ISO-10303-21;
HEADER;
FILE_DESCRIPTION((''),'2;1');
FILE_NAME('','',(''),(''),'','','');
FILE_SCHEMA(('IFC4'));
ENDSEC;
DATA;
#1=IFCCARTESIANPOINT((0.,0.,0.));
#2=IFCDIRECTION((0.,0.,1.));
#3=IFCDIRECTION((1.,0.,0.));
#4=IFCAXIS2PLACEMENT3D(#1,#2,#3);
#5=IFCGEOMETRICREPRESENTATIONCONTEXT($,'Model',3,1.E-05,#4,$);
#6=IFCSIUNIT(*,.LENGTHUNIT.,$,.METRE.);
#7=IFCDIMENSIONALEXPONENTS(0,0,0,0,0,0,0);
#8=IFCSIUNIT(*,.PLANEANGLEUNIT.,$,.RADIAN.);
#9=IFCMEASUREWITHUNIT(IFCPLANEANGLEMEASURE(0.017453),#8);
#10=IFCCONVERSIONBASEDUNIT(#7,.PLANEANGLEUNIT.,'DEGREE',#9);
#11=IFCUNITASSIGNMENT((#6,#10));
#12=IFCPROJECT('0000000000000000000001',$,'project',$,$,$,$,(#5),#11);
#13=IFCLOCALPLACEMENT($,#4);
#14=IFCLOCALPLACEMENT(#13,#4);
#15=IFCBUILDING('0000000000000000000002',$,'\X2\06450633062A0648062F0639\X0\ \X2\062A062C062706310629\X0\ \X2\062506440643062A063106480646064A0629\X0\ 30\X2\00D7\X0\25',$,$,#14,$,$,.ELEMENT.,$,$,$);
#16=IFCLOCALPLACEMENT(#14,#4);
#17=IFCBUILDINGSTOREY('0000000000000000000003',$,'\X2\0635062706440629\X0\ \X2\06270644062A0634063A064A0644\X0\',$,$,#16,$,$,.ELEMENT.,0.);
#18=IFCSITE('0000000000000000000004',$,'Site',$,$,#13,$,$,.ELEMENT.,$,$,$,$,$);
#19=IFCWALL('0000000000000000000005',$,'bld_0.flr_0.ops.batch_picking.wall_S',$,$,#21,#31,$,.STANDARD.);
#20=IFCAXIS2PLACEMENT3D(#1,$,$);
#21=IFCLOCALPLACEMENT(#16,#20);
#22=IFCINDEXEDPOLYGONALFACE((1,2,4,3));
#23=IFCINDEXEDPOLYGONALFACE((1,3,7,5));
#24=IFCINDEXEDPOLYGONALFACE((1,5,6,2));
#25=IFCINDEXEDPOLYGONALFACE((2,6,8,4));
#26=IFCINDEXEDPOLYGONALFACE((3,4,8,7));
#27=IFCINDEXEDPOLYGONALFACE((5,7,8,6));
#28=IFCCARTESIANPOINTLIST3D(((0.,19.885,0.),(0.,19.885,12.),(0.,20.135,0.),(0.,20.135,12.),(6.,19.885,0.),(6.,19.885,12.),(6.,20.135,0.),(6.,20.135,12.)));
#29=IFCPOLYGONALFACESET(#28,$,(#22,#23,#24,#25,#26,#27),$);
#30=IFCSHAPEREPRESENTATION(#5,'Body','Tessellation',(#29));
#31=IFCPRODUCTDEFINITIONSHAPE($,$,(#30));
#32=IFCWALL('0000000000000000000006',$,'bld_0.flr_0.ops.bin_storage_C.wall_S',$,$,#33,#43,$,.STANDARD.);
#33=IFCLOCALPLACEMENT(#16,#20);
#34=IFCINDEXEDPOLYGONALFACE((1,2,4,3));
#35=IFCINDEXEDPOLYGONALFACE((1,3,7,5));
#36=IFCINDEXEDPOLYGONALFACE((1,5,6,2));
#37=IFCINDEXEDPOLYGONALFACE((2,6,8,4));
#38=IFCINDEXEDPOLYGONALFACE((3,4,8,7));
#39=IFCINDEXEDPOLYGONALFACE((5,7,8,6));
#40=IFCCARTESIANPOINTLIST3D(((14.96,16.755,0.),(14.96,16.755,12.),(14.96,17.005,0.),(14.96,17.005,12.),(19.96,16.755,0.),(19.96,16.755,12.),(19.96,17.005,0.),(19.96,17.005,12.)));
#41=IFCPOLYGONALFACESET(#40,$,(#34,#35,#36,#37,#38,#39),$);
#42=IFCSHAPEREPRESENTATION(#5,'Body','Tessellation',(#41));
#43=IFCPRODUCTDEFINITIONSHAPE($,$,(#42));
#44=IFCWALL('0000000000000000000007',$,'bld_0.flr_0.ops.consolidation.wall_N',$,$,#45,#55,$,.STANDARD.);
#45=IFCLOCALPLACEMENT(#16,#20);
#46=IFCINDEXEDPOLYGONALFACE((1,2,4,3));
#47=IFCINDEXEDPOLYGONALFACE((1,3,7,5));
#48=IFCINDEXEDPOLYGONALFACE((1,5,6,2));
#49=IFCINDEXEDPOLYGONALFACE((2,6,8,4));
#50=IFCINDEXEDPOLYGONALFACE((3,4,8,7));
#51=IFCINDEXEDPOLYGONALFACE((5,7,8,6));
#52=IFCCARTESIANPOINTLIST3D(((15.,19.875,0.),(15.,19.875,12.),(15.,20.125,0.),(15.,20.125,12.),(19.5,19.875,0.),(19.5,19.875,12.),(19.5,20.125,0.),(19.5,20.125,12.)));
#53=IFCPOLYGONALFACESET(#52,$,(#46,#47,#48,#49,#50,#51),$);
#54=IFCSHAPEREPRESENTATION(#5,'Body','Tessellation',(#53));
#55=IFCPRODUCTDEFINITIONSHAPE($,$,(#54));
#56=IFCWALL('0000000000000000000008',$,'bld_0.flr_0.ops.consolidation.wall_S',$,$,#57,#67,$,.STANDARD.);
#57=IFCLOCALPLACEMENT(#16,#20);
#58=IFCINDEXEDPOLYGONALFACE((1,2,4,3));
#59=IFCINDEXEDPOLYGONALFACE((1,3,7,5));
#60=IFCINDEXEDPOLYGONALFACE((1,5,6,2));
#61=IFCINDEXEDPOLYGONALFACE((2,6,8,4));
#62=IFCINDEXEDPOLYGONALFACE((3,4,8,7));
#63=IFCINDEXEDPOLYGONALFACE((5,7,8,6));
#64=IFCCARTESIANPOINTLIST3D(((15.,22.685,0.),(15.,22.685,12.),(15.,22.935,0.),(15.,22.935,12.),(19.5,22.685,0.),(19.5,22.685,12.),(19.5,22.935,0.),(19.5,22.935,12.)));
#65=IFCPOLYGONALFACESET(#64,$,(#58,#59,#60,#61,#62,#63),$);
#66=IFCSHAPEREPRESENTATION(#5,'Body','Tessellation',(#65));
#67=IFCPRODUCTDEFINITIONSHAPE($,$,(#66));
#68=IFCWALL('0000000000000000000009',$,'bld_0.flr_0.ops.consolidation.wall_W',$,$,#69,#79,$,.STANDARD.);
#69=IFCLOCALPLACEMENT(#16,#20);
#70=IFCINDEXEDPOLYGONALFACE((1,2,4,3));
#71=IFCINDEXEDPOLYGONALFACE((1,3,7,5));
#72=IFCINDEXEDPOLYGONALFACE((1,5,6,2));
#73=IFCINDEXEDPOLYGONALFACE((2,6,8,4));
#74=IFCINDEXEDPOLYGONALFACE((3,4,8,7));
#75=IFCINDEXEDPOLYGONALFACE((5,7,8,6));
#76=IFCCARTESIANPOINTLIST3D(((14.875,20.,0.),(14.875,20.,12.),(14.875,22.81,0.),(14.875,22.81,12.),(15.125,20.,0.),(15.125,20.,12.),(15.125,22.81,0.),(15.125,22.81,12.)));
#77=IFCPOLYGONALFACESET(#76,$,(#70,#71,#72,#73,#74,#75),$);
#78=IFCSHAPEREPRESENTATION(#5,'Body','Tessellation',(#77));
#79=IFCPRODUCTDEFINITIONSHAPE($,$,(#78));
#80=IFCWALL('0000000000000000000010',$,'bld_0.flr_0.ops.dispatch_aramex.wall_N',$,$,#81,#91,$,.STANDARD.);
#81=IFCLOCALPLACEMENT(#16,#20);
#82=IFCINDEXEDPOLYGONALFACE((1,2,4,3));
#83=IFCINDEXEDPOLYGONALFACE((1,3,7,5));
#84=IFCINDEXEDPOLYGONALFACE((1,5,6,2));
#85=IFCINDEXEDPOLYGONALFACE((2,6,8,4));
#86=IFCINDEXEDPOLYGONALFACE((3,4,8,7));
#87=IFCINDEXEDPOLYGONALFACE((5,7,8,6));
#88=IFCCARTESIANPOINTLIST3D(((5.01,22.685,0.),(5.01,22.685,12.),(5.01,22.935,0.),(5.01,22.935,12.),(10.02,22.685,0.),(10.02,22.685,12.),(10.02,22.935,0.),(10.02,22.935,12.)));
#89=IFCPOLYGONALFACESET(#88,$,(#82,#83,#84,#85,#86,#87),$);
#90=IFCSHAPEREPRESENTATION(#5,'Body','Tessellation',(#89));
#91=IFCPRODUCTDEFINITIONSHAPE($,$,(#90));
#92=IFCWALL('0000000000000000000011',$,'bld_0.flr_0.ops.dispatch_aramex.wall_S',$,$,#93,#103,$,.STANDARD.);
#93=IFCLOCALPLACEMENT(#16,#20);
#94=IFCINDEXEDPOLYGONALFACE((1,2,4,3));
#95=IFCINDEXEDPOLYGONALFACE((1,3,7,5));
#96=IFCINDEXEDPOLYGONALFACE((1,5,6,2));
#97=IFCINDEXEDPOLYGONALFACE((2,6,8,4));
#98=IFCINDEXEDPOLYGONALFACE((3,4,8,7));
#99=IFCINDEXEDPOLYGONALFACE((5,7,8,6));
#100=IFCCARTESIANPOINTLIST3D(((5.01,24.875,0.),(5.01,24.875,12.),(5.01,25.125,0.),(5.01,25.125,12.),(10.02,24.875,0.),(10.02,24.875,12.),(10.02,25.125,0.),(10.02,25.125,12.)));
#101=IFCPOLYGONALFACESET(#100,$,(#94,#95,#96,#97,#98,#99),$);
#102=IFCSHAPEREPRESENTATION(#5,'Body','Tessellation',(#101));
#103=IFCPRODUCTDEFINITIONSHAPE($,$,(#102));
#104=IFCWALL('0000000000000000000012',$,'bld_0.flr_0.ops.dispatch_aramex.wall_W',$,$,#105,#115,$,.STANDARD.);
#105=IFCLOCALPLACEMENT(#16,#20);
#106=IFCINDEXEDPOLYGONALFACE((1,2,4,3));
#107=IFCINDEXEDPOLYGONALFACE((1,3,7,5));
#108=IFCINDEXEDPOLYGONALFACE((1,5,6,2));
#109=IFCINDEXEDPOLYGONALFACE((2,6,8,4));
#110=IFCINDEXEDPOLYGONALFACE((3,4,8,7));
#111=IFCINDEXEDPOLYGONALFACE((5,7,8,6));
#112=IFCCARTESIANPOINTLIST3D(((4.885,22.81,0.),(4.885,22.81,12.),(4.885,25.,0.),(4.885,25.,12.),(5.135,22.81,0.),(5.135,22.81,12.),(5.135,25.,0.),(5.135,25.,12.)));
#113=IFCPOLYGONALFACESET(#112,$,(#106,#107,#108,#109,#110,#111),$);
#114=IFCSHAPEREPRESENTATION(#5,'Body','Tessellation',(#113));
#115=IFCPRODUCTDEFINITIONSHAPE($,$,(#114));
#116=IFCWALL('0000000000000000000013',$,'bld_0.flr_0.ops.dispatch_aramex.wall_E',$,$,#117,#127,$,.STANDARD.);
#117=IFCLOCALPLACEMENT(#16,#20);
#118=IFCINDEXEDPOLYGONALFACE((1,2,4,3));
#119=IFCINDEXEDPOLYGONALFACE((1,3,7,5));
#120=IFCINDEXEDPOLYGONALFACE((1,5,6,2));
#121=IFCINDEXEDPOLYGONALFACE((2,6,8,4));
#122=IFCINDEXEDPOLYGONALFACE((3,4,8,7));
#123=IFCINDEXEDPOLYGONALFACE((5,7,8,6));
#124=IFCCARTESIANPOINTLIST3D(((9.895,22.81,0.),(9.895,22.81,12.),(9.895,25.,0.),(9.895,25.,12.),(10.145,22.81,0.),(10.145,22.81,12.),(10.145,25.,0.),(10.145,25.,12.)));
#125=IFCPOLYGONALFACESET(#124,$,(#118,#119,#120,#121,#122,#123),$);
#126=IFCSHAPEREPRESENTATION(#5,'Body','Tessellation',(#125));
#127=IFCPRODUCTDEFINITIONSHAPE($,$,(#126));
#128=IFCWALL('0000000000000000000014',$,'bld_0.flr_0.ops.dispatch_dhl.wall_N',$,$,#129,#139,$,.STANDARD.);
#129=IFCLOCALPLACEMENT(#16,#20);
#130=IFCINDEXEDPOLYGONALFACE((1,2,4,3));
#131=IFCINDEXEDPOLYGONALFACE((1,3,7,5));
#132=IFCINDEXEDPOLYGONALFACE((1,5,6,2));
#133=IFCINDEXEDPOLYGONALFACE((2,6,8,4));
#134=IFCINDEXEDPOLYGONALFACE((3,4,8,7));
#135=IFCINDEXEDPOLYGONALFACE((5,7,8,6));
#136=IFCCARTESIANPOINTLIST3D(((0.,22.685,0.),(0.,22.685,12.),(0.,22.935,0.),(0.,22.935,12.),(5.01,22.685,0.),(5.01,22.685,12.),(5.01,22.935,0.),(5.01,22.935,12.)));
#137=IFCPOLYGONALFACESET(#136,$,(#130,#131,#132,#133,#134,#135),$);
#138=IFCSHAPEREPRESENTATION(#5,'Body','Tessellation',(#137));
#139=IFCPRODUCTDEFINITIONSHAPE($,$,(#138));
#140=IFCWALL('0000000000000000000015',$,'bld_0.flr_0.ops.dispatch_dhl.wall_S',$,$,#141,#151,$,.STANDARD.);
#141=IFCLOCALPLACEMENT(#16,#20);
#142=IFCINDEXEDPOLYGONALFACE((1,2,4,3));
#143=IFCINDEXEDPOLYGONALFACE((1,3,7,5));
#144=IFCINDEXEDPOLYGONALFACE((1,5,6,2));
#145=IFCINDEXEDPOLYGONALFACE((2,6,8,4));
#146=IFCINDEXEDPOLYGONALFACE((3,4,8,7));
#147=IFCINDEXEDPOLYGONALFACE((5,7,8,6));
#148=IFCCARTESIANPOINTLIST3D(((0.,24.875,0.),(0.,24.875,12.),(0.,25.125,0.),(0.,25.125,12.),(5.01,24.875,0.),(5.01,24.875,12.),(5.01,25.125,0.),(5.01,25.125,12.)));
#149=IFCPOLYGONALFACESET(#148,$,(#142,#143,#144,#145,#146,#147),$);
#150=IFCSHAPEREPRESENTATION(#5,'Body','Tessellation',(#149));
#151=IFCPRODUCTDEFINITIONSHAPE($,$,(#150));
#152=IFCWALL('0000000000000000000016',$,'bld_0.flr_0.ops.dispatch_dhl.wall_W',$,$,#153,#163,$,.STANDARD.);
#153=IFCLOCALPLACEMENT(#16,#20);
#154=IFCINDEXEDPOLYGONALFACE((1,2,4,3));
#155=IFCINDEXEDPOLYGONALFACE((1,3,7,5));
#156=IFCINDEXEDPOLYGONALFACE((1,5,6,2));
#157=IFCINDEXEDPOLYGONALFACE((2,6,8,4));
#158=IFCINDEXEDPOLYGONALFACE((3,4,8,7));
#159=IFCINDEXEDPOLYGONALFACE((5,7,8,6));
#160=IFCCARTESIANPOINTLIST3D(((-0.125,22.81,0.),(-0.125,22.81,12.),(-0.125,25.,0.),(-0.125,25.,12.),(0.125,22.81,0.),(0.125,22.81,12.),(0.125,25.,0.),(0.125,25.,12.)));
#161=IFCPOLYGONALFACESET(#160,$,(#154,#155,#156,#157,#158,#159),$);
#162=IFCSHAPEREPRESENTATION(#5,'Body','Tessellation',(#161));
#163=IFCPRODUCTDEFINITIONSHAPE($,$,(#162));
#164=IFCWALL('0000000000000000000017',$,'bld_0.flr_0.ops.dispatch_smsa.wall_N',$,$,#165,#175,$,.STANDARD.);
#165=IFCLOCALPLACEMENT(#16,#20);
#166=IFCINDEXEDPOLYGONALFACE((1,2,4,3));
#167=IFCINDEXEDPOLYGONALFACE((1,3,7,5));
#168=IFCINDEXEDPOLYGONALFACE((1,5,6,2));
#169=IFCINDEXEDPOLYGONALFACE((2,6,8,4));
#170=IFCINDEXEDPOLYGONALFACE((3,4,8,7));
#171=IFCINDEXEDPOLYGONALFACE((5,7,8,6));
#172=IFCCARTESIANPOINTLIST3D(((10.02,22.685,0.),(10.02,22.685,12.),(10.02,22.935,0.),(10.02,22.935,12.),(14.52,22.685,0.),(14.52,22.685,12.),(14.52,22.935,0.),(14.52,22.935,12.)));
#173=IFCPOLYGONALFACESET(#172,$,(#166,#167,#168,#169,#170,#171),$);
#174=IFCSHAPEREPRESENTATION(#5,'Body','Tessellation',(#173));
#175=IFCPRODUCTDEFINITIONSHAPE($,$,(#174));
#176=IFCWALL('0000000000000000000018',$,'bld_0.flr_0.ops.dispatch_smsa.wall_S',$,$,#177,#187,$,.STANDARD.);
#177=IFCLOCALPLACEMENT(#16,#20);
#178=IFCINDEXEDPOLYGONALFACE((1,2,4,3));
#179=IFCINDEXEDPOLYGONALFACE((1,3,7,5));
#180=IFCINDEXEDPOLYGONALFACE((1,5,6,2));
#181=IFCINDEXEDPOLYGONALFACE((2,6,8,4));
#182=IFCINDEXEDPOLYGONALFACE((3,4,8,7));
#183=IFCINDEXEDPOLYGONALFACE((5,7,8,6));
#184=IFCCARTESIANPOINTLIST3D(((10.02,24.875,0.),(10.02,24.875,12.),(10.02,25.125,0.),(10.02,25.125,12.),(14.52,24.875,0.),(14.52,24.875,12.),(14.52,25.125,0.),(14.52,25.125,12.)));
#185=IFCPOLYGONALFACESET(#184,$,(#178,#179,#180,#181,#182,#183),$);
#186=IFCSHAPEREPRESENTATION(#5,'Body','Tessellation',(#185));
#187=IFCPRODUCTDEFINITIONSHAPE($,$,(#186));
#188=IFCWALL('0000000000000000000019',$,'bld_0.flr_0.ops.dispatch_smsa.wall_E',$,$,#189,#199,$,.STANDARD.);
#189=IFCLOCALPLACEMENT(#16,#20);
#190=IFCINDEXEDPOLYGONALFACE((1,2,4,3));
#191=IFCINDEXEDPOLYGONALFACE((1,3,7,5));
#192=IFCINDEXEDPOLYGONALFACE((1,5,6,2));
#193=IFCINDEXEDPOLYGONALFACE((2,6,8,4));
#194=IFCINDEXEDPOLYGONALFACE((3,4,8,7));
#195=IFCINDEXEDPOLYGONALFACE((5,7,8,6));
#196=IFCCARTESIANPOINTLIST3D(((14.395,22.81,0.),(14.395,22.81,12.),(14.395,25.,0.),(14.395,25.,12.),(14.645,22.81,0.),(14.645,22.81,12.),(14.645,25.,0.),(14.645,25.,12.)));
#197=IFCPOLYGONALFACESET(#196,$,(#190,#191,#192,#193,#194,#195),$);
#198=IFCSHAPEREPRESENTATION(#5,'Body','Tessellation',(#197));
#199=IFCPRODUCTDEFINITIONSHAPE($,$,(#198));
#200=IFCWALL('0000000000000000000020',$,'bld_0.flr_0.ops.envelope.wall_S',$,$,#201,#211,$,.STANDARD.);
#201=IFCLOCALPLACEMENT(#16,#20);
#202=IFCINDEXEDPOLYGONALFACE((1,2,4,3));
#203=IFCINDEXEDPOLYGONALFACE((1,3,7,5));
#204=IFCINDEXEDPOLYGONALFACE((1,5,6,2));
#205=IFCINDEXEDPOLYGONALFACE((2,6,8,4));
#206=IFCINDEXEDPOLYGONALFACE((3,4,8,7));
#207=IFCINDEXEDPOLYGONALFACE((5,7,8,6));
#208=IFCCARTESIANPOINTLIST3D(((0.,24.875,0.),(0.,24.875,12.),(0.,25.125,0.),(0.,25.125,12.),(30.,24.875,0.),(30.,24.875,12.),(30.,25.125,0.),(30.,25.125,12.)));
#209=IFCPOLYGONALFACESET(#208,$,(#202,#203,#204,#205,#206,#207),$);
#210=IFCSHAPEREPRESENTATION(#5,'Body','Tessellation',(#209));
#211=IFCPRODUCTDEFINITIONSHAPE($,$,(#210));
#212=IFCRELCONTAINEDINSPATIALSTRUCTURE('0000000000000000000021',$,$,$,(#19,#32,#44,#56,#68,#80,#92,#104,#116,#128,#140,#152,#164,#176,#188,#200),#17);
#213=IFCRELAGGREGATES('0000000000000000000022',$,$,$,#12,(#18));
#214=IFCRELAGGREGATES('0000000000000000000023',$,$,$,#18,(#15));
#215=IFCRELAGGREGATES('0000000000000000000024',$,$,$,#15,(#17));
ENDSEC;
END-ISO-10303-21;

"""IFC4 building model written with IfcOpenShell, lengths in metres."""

from ifc_helpers import new_model, entity, si_unit, converted_unit, frame, frame_2d, origin_with_axes, place, context, project, spatial, rectangle, extrude, element, save


model = new_model("IFC4")

# Units and contexts
model_context = context("Model", 3, precision=1e-05, world=origin_with_axes())
ifc_project = project(units=[si_unit("LENGTHUNIT", "METRE"), converted_unit("PLANEANGLEUNIT", "DEGREE", entity("IfcPlaneAngleMeasure", 0.017453), si_unit("PLANEANGLEUNIT", "RADIAN"), dimensions=[0, 0, 0, 0, 0, 0, 0])], contexts=[model_context])

# Site, building, storey
site_placement = place(None, origin_with_axes())
site = spatial("IfcSite", under=ifc_project, at=site_placement, Name="Site", CompositionType="ELEMENT")
building_placement = place(site_placement, origin_with_axes())
building = spatial("IfcBuilding", under=site, at=building_placement, Name="مستودع تجارة إلكترونية 30×25", CompositionType="ELEMENT")
storey_placement = place(building_placement, origin_with_axes())
storey = spatial("IfcBuildingStorey", under=building, at=storey_placement, Name="صالة التشغيل", CompositionType="ELEMENT", Elevation=0.0)

# Walls
wall_1_placement = place(storey_placement, frame((0.0, 20.01, 0.0), z_axis=(0.0, 0.0, 1.0), x_axis=(1.0, 0.0, 0.0)))
element("IfcWall", 1, at=wall_1_placement, inside=storey, Name="bld_0.flr_0.ops.batch_picking.wall_S", PredefinedType="STANDARD", context=model_context, shape_type="SweptSolid", body=[
    extrude(rectangle(XDim=6.0, YDim=0.25, at=frame_2d((3.0, 0.0), x_axis=(1.0, 0.0))), origin_with_axes(), (0.0, 0.0, 1.0), 12.0),
])
wall_2_placement = place(storey_placement, frame((14.96, 16.88, 0.0), z_axis=(0.0, 0.0, 1.0), x_axis=(1.0, 0.0, 0.0)))
element("IfcWall", 2, at=wall_2_placement, inside=storey, Name="bld_0.flr_0.ops.bin_storage_C.wall_S", PredefinedType="STANDARD", context=model_context, shape_type="SweptSolid", body=[
    extrude(rectangle(XDim=5.0, YDim=0.25, at=frame_2d((2.5, 0.0), x_axis=(1.0, 0.0))), origin_with_axes(), (0.0, 0.0, 1.0), 12.0),
])
for number, where, z_axis, x_axis, name in (
    (3, (15.0, 20.0, 0.0), (0.0, 0.0, 1.0), (1.0, 0.0, 0.0), "bld_0.flr_0.ops.consolidation.wall_N"),
    (4, (15.0, 22.81, 0.0), (0.0, 0.0, 1.0), (1.0, 0.0, 0.0), "bld_0.flr_0.ops.consolidation.wall_S"),
):
    element("IfcWall", number, at=place(storey_placement, frame(where, z_axis=z_axis, x_axis=x_axis)), inside=storey, Name=name, PredefinedType="STANDARD", context=model_context, shape_type="SweptSolid", body=[
        extrude(rectangle(XDim=4.5, YDim=0.25, at=frame_2d((2.25, 0.0), x_axis=(1.0, 0.0))), origin_with_axes(), (0.0, 0.0, 1.0), 12.0),
    ])
wall_3_placement = place(storey_placement, frame((15.0, 20.0, 0.0), z_axis=(0.0, 0.0, 1.0), x_axis=(0.0, 1.0, 0.0)))
element("IfcWall", 5, at=wall_3_placement, inside=storey, Name="bld_0.flr_0.ops.consolidation.wall_W", PredefinedType="STANDARD", context=model_context, shape_type="SweptSolid", body=[
    extrude(rectangle(XDim=2.81, YDim=0.25, at=frame_2d((1.405, 0.0), x_axis=(1.0, 0.0))), origin_with_axes(), (0.0, 0.0, 1.0), 12.0),
])
for number, where, z_axis, x_axis, name in (
    (6, (5.01, 22.81, 0.0), (0.0, 0.0, 1.0), (1.0, 0.0, 0.0), "bld_0.flr_0.ops.dispatch_aramex.wall_N"),
    (7, (5.01, 25.0, 0.0), (0.0, 0.0, 1.0), (1.0, 0.0, 0.0), "bld_0.flr_0.ops.dispatch_aramex.wall_S"),
):
    element("IfcWall", number, at=place(storey_placement, frame(where, z_axis=z_axis, x_axis=x_axis)), inside=storey, Name=name, PredefinedType="STANDARD", context=model_context, shape_type="SweptSolid", body=[
        extrude(rectangle(XDim=5.01, YDim=0.25, at=frame_2d((2.505, 0.0), x_axis=(1.0, 0.0))), origin_with_axes(), (0.0, 0.0, 1.0), 12.0),
    ])
for number, where, z_axis, x_axis, name in (
    (8, (5.01, 22.81, 0.0), (0.0, 0.0, 1.0), (0.0, 1.0, 0.0), "bld_0.flr_0.ops.dispatch_aramex.wall_W"),
    (9, (10.02, 22.81, 0.0), (0.0, 0.0, 1.0), (0.0, 1.0, 0.0), "bld_0.flr_0.ops.dispatch_aramex.wall_E"),
):
    element("IfcWall", number, at=place(storey_placement, frame(where, z_axis=z_axis, x_axis=x_axis)), inside=storey, Name=name, PredefinedType="STANDARD", context=model_context, shape_type="SweptSolid", body=[
        extrude(rectangle(XDim=2.19, YDim=0.25, at=frame_2d((1.095, 0.0), x_axis=(1.0, 0.0))), origin_with_axes(), (0.0, 0.0, 1.0), 12.0),
    ])
for number, where, z_axis, x_axis, name in (
    (10, (0.0, 22.81, 0.0), (0.0, 0.0, 1.0), (1.0, 0.0, 0.0), "bld_0.flr_0.ops.dispatch_dhl.wall_N"),
    (11, (0.0, 25.0, 0.0), (0.0, 0.0, 1.0), (1.0, 0.0, 0.0), "bld_0.flr_0.ops.dispatch_dhl.wall_S"),
):
    element("IfcWall", number, at=place(storey_placement, frame(where, z_axis=z_axis, x_axis=x_axis)), inside=storey, Name=name, PredefinedType="STANDARD", context=model_context, shape_type="SweptSolid", body=[
        extrude(rectangle(XDim=5.01, YDim=0.25, at=frame_2d((2.505, 0.0), x_axis=(1.0, 0.0))), origin_with_axes(), (0.0, 0.0, 1.0), 12.0),
    ])
for number, where, z_axis, x_axis, name in (
    (12, (0.0, 22.81, 0.0), (0.0, 0.0, 1.0), (0.0, 1.0, 0.0), "bld_0.flr_0.ops.dispatch_dhl.wall_W"),
):
    element("IfcWall", number, at=place(storey_placement, frame(where, z_axis=z_axis, x_axis=x_axis)), inside=storey, Name=name, PredefinedType="STANDARD", context=model_context, shape_type="SweptSolid", body=[
        extrude(rectangle(XDim=2.19, YDim=0.25, at=frame_2d((1.095, 0.0), x_axis=(1.0, 0.0))), origin_with_axes(), (0.0, 0.0, 1.0), 12.0),
    ])
for number, where, z_axis, x_axis, name in (
    (13, (10.02, 22.81, 0.0), (0.0, 0.0, 1.0), (1.0, 0.0, 0.0), "bld_0.flr_0.ops.dispatch_smsa.wall_N"),
    (14, (10.02, 25.0, 0.0), (0.0, 0.0, 1.0), (1.0, 0.0, 0.0), "bld_0.flr_0.ops.dispatch_smsa.wall_S"),
):
    element("IfcWall", number, at=place(storey_placement, frame(where, z_axis=z_axis, x_axis=x_axis)), inside=storey, Name=name, PredefinedType="STANDARD", context=model_context, shape_type="SweptSolid", body=[
        extrude(rectangle(XDim=4.5, YDim=0.25, at=frame_2d((2.25, 0.0), x_axis=(1.0, 0.0))), origin_with_axes(), (0.0, 0.0, 1.0), 12.0),
    ])
for number, where, z_axis, x_axis, name in (
    (15, (14.52, 22.81, 0.0), (0.0, 0.0, 1.0), (0.0, 1.0, 0.0), "bld_0.flr_0.ops.dispatch_smsa.wall_E"),
):
    element("IfcWall", number, at=place(storey_placement, frame(where, z_axis=z_axis, x_axis=x_axis)), inside=storey, Name=name, PredefinedType="STANDARD", context=model_context, shape_type="SweptSolid", body=[
        extrude(rectangle(XDim=2.19, YDim=0.25, at=frame_2d((1.095, 0.0), x_axis=(1.0, 0.0))), origin_with_axes(), (0.0, 0.0, 1.0), 12.0),
    ])
wall_4_placement = place(storey_placement, frame((0.0, 25.0, 0.0), z_axis=(0.0, 0.0, 1.0), x_axis=(1.0, 0.0, 0.0)))
element("IfcWall", 16, at=wall_4_placement, inside=storey, Name="bld_0.flr_0.ops.envelope.wall_S", PredefinedType="STANDARD", context=model_context, shape_type="SweptSolid", body=[
    extrude(rectangle(XDim=30.0, YDim=0.25, at=frame_2d((15.0, 0.0), x_axis=(1.0, 0.0))), origin_with_axes(), (0.0, 0.0, 1.0), 12.0),
])

save(model, "model.ifc")
